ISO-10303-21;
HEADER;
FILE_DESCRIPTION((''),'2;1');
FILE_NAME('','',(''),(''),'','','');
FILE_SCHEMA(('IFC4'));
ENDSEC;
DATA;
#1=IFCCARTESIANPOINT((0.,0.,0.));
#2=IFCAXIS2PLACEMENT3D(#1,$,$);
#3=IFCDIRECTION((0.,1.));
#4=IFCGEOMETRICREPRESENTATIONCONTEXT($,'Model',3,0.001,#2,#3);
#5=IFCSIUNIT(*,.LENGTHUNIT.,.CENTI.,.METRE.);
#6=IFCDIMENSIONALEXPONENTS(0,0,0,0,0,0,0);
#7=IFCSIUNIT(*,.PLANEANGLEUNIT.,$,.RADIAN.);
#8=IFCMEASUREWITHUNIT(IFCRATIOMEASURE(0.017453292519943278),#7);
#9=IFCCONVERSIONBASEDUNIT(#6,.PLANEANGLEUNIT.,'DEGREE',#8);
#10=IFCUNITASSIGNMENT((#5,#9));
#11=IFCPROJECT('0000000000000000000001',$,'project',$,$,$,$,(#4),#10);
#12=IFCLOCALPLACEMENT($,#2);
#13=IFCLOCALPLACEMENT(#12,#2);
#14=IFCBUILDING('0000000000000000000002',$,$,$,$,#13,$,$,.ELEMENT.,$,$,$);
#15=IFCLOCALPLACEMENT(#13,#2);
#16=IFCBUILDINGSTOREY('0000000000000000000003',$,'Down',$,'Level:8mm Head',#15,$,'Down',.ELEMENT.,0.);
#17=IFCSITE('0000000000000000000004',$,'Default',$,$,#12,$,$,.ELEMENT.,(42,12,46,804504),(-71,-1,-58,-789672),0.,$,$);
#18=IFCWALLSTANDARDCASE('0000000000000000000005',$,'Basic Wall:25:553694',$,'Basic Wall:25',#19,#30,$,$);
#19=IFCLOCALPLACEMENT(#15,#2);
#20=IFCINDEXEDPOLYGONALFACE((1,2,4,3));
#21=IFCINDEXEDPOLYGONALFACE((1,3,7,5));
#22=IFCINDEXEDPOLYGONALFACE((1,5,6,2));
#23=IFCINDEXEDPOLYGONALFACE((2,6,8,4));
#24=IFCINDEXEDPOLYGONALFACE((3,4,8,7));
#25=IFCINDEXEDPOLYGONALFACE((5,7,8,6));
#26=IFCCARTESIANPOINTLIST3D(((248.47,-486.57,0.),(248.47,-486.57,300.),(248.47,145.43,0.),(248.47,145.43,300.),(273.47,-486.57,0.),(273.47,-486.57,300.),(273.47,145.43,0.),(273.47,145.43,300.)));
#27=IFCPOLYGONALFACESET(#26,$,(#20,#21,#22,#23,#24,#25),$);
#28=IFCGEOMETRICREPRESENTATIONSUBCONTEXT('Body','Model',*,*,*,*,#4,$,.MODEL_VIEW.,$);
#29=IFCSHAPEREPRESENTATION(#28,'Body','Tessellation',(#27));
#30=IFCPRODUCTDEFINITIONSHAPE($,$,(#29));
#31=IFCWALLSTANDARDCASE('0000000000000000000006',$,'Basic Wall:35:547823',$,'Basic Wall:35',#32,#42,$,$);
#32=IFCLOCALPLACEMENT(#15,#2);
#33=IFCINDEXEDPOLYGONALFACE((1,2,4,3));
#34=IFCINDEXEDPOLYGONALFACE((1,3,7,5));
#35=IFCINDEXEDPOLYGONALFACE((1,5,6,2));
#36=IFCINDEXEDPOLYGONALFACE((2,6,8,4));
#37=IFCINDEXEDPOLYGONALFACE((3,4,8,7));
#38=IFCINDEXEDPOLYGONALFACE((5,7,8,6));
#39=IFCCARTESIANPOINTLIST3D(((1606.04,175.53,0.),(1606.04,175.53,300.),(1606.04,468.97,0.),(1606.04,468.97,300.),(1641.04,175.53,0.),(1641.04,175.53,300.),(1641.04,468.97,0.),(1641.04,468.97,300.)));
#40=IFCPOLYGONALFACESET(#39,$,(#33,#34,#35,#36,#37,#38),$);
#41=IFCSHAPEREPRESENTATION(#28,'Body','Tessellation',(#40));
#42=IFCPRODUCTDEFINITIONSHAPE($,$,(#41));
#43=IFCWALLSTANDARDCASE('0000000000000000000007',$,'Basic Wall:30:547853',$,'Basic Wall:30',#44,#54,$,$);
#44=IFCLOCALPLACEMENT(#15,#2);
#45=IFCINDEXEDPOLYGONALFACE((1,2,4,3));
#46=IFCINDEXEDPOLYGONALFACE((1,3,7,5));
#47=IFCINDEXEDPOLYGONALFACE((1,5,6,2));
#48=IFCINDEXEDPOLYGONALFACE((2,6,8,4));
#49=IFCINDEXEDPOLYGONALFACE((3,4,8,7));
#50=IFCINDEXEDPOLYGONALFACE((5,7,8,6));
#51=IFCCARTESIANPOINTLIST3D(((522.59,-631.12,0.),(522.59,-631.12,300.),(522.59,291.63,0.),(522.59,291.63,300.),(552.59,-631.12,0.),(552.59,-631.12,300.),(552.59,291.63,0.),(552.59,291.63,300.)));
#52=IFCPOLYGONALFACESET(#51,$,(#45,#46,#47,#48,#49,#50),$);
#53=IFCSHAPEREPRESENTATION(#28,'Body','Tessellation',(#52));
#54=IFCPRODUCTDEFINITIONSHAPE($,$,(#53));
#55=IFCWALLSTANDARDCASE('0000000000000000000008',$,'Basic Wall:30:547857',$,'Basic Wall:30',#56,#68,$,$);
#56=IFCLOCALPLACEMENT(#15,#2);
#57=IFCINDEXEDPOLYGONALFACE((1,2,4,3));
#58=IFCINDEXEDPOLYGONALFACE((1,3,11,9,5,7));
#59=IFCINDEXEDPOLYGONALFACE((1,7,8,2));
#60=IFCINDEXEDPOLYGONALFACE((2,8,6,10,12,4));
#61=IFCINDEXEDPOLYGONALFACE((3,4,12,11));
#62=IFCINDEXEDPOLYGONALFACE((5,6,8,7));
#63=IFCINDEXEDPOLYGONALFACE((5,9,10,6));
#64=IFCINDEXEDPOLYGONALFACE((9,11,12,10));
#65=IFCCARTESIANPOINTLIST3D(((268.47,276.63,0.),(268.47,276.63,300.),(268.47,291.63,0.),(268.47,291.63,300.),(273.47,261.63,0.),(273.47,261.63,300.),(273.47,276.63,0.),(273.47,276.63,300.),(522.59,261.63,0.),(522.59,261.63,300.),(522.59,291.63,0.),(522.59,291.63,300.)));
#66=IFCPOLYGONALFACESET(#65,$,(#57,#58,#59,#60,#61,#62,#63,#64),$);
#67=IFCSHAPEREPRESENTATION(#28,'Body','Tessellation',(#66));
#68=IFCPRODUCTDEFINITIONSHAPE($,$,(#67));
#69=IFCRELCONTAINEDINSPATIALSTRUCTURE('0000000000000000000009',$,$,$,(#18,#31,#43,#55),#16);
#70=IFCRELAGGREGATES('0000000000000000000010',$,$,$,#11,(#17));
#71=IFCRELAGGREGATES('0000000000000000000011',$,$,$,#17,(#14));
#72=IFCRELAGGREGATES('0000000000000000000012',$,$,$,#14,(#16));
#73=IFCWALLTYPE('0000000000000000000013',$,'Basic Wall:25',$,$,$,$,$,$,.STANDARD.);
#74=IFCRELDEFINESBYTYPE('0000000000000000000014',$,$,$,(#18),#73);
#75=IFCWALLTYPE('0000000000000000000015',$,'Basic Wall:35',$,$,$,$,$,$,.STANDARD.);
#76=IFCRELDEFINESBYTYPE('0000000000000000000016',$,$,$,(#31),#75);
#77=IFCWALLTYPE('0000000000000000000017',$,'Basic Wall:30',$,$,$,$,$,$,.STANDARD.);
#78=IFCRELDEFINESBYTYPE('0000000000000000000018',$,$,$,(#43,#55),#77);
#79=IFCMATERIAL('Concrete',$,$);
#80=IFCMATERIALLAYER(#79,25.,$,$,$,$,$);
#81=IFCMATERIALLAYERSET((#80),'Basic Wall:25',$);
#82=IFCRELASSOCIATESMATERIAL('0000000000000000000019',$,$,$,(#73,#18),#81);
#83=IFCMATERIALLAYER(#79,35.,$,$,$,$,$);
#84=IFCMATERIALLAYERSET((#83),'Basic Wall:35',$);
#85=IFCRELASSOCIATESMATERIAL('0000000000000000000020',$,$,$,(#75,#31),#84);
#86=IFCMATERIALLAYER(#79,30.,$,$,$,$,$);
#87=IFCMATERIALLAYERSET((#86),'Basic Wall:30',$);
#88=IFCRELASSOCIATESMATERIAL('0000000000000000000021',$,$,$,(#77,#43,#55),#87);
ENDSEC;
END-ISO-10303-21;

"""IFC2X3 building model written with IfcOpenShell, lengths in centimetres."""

from ifc_helpers import new_model, entity, si_unit, converted_unit, direction, frame, frame_2d, origin, place, context, subcontext, project, spatial, polyline, rectangle, outline, extrude, material, layer, layer_set, layer_usage, type_object, element, save


model = new_model("IFC2X3")

# Units and contexts
model_context = context("Model", 3, precision=0.001, world=origin(), true_north=direction((0.0, 1.0)))
body_context = subcontext(model_context, "Body", "Model", "MODEL_VIEW")
ifc_project = project(units=[si_unit("LENGTHUNIT", "METRE", prefix="CENTI"), converted_unit("PLANEANGLEUNIT", "DEGREE", entity("IfcRatioMeasure", 0.017453292519943278), si_unit("PLANEANGLEUNIT", "RADIAN"), dimensions=[0, 0, 0, 0, 0, 0, 0])], contexts=[model_context])

# Site, building, storey
site_placement = place(None, origin())
site = spatial("IfcSite", under=ifc_project, at=site_placement, Name="Default", CompositionType="ELEMENT", RefLatitude=(42, 12, 46, 804504), RefLongitude=(-71, -1, -58, -789672), RefElevation=0.0)
building_placement = place(site_placement, origin())
building = spatial("IfcBuilding", under=site, at=building_placement, CompositionType="ELEMENT")
storey_placement = place(building_placement, origin())
storey = spatial("IfcBuildingStorey", under=building, at=storey_placement, Name="Down", ObjectType="Level:8mm Head", LongName="Down", CompositionType="ELEMENT", Elevation=0.0)

# Shared definitions
ifc_material = material(Name="Concrete")

# Walls
ifc_layer_1 = layer(ifc_material, 25.0)
ifc_layer_set_1 = layer_set([ifc_layer_1], Name="Basic Wall:25")
wall_type_1 = type_object("IfcWallType", Name="Basic Wall:25", PredefinedType="STANDARD", material=ifc_layer_set_1)
ifc_layer_usage_1 = layer_usage(ifc_layer_set_1, "AXIS2", "POSITIVE", -12.5)
wall_1_placement = place(storey_placement, frame((260.97, 145.43, 0.0), z_axis=(0.0, 0.0, 1.0), x_axis=(0.0, -1.0, 0.0)))
element("IfcWallStandardCase", 1, at=wall_1_placement, inside=storey, type_object=wall_type_1, material=ifc_layer_usage_1, Name="Basic Wall:25:553694", ObjectType="Basic Wall:25", context=body_context, shape_type="SweptSolid", body=[
    extrude(rectangle(XDim=632.0, YDim=25.0, at=frame_2d((316.0, 0.0), x_axis=(-1.0, 0.0))), origin(), (0.0, 0.0, 1.0), 300.0),
])
ifc_layer_2 = layer(ifc_material, 35.0)
ifc_layer_set_2 = layer_set([ifc_layer_2], Name="Basic Wall:35")
ifc_layer_usage_2 = layer_usage(ifc_layer_set_2, "AXIS2", "NEGATIVE", 17.5)
wall_type_2 = type_object("IfcWallType", Name="Basic Wall:35", PredefinedType="STANDARD", material=ifc_layer_set_2)
wall_2_placement = place(storey_placement, frame((1623.54, 175.53, 0.0), z_axis=(0.0, 0.0, 1.0), x_axis=(0.0, 1.0, 0.0)))
element("IfcWallStandardCase", 2, at=wall_2_placement, inside=storey, type_object=wall_type_2, material=ifc_layer_usage_2, Name="Basic Wall:35:547823", ObjectType="Basic Wall:35", context=body_context, shape_type="SweptSolid", body=[
    extrude(rectangle(XDim=293.44, YDim=35.0, at=frame_2d((146.72, 0.0), x_axis=(-1.0, 0.0))), origin(), (0.0, 0.0, 1.0), 300.0),
])
ifc_layer_3 = layer(ifc_material, 30.0)
ifc_layer_set_3 = layer_set([ifc_layer_3], Name="Basic Wall:30")
ifc_layer_usage_3 = layer_usage(ifc_layer_set_3, "AXIS2", "NEGATIVE", 15.0)
wall_type_3 = type_object("IfcWallType", Name="Basic Wall:30", PredefinedType="STANDARD", material=ifc_layer_set_3)
wall_3_placement = place(storey_placement, frame((537.59, 291.63, 0.0), z_axis=(0.0, 0.0, 1.0), x_axis=(0.0, -1.0, 0.0)))
element("IfcWallStandardCase", 3, at=wall_3_placement, inside=storey, type_object=wall_type_3, material=ifc_layer_usage_3, Name="Basic Wall:30:547853", ObjectType="Basic Wall:30", context=body_context, shape_type="SweptSolid", body=[
    extrude(rectangle(XDim=922.75, YDim=30.0, at=frame_2d((461.37, 0.0), x_axis=(-1.0, 0.0))), origin(), (0.0, 0.0, 1.0), 300.0),
])
ifc_layer_usage_4 = layer_usage(ifc_layer_set_3, "AXIS2", "POSITIVE", -15.0)
wall_4_placement = place(storey_placement, frame((522.59, 276.63, 0.0), z_axis=(0.0, 0.0, 1.0), x_axis=(-1.0, 0.0, 0.0)))
element("IfcWallStandardCase", 4, at=wall_4_placement, inside=storey, type_object=wall_type_3, material=ifc_layer_usage_4, Name="Basic Wall:30:547857", ObjectType="Basic Wall:30", context=body_context, shape_type="SweptSolid", body=[
    extrude(outline(polyline([(254.12, -15.0), (254.12, 0.0), (249.12, 0.0), (249.12, 15.0), (0.0, 15.0), (0.0, -15.0), (254.12, -15.0)])), origin(), (0.0, 0.0, 1.0), 300.0),
])

save(model, "model.ifc")
